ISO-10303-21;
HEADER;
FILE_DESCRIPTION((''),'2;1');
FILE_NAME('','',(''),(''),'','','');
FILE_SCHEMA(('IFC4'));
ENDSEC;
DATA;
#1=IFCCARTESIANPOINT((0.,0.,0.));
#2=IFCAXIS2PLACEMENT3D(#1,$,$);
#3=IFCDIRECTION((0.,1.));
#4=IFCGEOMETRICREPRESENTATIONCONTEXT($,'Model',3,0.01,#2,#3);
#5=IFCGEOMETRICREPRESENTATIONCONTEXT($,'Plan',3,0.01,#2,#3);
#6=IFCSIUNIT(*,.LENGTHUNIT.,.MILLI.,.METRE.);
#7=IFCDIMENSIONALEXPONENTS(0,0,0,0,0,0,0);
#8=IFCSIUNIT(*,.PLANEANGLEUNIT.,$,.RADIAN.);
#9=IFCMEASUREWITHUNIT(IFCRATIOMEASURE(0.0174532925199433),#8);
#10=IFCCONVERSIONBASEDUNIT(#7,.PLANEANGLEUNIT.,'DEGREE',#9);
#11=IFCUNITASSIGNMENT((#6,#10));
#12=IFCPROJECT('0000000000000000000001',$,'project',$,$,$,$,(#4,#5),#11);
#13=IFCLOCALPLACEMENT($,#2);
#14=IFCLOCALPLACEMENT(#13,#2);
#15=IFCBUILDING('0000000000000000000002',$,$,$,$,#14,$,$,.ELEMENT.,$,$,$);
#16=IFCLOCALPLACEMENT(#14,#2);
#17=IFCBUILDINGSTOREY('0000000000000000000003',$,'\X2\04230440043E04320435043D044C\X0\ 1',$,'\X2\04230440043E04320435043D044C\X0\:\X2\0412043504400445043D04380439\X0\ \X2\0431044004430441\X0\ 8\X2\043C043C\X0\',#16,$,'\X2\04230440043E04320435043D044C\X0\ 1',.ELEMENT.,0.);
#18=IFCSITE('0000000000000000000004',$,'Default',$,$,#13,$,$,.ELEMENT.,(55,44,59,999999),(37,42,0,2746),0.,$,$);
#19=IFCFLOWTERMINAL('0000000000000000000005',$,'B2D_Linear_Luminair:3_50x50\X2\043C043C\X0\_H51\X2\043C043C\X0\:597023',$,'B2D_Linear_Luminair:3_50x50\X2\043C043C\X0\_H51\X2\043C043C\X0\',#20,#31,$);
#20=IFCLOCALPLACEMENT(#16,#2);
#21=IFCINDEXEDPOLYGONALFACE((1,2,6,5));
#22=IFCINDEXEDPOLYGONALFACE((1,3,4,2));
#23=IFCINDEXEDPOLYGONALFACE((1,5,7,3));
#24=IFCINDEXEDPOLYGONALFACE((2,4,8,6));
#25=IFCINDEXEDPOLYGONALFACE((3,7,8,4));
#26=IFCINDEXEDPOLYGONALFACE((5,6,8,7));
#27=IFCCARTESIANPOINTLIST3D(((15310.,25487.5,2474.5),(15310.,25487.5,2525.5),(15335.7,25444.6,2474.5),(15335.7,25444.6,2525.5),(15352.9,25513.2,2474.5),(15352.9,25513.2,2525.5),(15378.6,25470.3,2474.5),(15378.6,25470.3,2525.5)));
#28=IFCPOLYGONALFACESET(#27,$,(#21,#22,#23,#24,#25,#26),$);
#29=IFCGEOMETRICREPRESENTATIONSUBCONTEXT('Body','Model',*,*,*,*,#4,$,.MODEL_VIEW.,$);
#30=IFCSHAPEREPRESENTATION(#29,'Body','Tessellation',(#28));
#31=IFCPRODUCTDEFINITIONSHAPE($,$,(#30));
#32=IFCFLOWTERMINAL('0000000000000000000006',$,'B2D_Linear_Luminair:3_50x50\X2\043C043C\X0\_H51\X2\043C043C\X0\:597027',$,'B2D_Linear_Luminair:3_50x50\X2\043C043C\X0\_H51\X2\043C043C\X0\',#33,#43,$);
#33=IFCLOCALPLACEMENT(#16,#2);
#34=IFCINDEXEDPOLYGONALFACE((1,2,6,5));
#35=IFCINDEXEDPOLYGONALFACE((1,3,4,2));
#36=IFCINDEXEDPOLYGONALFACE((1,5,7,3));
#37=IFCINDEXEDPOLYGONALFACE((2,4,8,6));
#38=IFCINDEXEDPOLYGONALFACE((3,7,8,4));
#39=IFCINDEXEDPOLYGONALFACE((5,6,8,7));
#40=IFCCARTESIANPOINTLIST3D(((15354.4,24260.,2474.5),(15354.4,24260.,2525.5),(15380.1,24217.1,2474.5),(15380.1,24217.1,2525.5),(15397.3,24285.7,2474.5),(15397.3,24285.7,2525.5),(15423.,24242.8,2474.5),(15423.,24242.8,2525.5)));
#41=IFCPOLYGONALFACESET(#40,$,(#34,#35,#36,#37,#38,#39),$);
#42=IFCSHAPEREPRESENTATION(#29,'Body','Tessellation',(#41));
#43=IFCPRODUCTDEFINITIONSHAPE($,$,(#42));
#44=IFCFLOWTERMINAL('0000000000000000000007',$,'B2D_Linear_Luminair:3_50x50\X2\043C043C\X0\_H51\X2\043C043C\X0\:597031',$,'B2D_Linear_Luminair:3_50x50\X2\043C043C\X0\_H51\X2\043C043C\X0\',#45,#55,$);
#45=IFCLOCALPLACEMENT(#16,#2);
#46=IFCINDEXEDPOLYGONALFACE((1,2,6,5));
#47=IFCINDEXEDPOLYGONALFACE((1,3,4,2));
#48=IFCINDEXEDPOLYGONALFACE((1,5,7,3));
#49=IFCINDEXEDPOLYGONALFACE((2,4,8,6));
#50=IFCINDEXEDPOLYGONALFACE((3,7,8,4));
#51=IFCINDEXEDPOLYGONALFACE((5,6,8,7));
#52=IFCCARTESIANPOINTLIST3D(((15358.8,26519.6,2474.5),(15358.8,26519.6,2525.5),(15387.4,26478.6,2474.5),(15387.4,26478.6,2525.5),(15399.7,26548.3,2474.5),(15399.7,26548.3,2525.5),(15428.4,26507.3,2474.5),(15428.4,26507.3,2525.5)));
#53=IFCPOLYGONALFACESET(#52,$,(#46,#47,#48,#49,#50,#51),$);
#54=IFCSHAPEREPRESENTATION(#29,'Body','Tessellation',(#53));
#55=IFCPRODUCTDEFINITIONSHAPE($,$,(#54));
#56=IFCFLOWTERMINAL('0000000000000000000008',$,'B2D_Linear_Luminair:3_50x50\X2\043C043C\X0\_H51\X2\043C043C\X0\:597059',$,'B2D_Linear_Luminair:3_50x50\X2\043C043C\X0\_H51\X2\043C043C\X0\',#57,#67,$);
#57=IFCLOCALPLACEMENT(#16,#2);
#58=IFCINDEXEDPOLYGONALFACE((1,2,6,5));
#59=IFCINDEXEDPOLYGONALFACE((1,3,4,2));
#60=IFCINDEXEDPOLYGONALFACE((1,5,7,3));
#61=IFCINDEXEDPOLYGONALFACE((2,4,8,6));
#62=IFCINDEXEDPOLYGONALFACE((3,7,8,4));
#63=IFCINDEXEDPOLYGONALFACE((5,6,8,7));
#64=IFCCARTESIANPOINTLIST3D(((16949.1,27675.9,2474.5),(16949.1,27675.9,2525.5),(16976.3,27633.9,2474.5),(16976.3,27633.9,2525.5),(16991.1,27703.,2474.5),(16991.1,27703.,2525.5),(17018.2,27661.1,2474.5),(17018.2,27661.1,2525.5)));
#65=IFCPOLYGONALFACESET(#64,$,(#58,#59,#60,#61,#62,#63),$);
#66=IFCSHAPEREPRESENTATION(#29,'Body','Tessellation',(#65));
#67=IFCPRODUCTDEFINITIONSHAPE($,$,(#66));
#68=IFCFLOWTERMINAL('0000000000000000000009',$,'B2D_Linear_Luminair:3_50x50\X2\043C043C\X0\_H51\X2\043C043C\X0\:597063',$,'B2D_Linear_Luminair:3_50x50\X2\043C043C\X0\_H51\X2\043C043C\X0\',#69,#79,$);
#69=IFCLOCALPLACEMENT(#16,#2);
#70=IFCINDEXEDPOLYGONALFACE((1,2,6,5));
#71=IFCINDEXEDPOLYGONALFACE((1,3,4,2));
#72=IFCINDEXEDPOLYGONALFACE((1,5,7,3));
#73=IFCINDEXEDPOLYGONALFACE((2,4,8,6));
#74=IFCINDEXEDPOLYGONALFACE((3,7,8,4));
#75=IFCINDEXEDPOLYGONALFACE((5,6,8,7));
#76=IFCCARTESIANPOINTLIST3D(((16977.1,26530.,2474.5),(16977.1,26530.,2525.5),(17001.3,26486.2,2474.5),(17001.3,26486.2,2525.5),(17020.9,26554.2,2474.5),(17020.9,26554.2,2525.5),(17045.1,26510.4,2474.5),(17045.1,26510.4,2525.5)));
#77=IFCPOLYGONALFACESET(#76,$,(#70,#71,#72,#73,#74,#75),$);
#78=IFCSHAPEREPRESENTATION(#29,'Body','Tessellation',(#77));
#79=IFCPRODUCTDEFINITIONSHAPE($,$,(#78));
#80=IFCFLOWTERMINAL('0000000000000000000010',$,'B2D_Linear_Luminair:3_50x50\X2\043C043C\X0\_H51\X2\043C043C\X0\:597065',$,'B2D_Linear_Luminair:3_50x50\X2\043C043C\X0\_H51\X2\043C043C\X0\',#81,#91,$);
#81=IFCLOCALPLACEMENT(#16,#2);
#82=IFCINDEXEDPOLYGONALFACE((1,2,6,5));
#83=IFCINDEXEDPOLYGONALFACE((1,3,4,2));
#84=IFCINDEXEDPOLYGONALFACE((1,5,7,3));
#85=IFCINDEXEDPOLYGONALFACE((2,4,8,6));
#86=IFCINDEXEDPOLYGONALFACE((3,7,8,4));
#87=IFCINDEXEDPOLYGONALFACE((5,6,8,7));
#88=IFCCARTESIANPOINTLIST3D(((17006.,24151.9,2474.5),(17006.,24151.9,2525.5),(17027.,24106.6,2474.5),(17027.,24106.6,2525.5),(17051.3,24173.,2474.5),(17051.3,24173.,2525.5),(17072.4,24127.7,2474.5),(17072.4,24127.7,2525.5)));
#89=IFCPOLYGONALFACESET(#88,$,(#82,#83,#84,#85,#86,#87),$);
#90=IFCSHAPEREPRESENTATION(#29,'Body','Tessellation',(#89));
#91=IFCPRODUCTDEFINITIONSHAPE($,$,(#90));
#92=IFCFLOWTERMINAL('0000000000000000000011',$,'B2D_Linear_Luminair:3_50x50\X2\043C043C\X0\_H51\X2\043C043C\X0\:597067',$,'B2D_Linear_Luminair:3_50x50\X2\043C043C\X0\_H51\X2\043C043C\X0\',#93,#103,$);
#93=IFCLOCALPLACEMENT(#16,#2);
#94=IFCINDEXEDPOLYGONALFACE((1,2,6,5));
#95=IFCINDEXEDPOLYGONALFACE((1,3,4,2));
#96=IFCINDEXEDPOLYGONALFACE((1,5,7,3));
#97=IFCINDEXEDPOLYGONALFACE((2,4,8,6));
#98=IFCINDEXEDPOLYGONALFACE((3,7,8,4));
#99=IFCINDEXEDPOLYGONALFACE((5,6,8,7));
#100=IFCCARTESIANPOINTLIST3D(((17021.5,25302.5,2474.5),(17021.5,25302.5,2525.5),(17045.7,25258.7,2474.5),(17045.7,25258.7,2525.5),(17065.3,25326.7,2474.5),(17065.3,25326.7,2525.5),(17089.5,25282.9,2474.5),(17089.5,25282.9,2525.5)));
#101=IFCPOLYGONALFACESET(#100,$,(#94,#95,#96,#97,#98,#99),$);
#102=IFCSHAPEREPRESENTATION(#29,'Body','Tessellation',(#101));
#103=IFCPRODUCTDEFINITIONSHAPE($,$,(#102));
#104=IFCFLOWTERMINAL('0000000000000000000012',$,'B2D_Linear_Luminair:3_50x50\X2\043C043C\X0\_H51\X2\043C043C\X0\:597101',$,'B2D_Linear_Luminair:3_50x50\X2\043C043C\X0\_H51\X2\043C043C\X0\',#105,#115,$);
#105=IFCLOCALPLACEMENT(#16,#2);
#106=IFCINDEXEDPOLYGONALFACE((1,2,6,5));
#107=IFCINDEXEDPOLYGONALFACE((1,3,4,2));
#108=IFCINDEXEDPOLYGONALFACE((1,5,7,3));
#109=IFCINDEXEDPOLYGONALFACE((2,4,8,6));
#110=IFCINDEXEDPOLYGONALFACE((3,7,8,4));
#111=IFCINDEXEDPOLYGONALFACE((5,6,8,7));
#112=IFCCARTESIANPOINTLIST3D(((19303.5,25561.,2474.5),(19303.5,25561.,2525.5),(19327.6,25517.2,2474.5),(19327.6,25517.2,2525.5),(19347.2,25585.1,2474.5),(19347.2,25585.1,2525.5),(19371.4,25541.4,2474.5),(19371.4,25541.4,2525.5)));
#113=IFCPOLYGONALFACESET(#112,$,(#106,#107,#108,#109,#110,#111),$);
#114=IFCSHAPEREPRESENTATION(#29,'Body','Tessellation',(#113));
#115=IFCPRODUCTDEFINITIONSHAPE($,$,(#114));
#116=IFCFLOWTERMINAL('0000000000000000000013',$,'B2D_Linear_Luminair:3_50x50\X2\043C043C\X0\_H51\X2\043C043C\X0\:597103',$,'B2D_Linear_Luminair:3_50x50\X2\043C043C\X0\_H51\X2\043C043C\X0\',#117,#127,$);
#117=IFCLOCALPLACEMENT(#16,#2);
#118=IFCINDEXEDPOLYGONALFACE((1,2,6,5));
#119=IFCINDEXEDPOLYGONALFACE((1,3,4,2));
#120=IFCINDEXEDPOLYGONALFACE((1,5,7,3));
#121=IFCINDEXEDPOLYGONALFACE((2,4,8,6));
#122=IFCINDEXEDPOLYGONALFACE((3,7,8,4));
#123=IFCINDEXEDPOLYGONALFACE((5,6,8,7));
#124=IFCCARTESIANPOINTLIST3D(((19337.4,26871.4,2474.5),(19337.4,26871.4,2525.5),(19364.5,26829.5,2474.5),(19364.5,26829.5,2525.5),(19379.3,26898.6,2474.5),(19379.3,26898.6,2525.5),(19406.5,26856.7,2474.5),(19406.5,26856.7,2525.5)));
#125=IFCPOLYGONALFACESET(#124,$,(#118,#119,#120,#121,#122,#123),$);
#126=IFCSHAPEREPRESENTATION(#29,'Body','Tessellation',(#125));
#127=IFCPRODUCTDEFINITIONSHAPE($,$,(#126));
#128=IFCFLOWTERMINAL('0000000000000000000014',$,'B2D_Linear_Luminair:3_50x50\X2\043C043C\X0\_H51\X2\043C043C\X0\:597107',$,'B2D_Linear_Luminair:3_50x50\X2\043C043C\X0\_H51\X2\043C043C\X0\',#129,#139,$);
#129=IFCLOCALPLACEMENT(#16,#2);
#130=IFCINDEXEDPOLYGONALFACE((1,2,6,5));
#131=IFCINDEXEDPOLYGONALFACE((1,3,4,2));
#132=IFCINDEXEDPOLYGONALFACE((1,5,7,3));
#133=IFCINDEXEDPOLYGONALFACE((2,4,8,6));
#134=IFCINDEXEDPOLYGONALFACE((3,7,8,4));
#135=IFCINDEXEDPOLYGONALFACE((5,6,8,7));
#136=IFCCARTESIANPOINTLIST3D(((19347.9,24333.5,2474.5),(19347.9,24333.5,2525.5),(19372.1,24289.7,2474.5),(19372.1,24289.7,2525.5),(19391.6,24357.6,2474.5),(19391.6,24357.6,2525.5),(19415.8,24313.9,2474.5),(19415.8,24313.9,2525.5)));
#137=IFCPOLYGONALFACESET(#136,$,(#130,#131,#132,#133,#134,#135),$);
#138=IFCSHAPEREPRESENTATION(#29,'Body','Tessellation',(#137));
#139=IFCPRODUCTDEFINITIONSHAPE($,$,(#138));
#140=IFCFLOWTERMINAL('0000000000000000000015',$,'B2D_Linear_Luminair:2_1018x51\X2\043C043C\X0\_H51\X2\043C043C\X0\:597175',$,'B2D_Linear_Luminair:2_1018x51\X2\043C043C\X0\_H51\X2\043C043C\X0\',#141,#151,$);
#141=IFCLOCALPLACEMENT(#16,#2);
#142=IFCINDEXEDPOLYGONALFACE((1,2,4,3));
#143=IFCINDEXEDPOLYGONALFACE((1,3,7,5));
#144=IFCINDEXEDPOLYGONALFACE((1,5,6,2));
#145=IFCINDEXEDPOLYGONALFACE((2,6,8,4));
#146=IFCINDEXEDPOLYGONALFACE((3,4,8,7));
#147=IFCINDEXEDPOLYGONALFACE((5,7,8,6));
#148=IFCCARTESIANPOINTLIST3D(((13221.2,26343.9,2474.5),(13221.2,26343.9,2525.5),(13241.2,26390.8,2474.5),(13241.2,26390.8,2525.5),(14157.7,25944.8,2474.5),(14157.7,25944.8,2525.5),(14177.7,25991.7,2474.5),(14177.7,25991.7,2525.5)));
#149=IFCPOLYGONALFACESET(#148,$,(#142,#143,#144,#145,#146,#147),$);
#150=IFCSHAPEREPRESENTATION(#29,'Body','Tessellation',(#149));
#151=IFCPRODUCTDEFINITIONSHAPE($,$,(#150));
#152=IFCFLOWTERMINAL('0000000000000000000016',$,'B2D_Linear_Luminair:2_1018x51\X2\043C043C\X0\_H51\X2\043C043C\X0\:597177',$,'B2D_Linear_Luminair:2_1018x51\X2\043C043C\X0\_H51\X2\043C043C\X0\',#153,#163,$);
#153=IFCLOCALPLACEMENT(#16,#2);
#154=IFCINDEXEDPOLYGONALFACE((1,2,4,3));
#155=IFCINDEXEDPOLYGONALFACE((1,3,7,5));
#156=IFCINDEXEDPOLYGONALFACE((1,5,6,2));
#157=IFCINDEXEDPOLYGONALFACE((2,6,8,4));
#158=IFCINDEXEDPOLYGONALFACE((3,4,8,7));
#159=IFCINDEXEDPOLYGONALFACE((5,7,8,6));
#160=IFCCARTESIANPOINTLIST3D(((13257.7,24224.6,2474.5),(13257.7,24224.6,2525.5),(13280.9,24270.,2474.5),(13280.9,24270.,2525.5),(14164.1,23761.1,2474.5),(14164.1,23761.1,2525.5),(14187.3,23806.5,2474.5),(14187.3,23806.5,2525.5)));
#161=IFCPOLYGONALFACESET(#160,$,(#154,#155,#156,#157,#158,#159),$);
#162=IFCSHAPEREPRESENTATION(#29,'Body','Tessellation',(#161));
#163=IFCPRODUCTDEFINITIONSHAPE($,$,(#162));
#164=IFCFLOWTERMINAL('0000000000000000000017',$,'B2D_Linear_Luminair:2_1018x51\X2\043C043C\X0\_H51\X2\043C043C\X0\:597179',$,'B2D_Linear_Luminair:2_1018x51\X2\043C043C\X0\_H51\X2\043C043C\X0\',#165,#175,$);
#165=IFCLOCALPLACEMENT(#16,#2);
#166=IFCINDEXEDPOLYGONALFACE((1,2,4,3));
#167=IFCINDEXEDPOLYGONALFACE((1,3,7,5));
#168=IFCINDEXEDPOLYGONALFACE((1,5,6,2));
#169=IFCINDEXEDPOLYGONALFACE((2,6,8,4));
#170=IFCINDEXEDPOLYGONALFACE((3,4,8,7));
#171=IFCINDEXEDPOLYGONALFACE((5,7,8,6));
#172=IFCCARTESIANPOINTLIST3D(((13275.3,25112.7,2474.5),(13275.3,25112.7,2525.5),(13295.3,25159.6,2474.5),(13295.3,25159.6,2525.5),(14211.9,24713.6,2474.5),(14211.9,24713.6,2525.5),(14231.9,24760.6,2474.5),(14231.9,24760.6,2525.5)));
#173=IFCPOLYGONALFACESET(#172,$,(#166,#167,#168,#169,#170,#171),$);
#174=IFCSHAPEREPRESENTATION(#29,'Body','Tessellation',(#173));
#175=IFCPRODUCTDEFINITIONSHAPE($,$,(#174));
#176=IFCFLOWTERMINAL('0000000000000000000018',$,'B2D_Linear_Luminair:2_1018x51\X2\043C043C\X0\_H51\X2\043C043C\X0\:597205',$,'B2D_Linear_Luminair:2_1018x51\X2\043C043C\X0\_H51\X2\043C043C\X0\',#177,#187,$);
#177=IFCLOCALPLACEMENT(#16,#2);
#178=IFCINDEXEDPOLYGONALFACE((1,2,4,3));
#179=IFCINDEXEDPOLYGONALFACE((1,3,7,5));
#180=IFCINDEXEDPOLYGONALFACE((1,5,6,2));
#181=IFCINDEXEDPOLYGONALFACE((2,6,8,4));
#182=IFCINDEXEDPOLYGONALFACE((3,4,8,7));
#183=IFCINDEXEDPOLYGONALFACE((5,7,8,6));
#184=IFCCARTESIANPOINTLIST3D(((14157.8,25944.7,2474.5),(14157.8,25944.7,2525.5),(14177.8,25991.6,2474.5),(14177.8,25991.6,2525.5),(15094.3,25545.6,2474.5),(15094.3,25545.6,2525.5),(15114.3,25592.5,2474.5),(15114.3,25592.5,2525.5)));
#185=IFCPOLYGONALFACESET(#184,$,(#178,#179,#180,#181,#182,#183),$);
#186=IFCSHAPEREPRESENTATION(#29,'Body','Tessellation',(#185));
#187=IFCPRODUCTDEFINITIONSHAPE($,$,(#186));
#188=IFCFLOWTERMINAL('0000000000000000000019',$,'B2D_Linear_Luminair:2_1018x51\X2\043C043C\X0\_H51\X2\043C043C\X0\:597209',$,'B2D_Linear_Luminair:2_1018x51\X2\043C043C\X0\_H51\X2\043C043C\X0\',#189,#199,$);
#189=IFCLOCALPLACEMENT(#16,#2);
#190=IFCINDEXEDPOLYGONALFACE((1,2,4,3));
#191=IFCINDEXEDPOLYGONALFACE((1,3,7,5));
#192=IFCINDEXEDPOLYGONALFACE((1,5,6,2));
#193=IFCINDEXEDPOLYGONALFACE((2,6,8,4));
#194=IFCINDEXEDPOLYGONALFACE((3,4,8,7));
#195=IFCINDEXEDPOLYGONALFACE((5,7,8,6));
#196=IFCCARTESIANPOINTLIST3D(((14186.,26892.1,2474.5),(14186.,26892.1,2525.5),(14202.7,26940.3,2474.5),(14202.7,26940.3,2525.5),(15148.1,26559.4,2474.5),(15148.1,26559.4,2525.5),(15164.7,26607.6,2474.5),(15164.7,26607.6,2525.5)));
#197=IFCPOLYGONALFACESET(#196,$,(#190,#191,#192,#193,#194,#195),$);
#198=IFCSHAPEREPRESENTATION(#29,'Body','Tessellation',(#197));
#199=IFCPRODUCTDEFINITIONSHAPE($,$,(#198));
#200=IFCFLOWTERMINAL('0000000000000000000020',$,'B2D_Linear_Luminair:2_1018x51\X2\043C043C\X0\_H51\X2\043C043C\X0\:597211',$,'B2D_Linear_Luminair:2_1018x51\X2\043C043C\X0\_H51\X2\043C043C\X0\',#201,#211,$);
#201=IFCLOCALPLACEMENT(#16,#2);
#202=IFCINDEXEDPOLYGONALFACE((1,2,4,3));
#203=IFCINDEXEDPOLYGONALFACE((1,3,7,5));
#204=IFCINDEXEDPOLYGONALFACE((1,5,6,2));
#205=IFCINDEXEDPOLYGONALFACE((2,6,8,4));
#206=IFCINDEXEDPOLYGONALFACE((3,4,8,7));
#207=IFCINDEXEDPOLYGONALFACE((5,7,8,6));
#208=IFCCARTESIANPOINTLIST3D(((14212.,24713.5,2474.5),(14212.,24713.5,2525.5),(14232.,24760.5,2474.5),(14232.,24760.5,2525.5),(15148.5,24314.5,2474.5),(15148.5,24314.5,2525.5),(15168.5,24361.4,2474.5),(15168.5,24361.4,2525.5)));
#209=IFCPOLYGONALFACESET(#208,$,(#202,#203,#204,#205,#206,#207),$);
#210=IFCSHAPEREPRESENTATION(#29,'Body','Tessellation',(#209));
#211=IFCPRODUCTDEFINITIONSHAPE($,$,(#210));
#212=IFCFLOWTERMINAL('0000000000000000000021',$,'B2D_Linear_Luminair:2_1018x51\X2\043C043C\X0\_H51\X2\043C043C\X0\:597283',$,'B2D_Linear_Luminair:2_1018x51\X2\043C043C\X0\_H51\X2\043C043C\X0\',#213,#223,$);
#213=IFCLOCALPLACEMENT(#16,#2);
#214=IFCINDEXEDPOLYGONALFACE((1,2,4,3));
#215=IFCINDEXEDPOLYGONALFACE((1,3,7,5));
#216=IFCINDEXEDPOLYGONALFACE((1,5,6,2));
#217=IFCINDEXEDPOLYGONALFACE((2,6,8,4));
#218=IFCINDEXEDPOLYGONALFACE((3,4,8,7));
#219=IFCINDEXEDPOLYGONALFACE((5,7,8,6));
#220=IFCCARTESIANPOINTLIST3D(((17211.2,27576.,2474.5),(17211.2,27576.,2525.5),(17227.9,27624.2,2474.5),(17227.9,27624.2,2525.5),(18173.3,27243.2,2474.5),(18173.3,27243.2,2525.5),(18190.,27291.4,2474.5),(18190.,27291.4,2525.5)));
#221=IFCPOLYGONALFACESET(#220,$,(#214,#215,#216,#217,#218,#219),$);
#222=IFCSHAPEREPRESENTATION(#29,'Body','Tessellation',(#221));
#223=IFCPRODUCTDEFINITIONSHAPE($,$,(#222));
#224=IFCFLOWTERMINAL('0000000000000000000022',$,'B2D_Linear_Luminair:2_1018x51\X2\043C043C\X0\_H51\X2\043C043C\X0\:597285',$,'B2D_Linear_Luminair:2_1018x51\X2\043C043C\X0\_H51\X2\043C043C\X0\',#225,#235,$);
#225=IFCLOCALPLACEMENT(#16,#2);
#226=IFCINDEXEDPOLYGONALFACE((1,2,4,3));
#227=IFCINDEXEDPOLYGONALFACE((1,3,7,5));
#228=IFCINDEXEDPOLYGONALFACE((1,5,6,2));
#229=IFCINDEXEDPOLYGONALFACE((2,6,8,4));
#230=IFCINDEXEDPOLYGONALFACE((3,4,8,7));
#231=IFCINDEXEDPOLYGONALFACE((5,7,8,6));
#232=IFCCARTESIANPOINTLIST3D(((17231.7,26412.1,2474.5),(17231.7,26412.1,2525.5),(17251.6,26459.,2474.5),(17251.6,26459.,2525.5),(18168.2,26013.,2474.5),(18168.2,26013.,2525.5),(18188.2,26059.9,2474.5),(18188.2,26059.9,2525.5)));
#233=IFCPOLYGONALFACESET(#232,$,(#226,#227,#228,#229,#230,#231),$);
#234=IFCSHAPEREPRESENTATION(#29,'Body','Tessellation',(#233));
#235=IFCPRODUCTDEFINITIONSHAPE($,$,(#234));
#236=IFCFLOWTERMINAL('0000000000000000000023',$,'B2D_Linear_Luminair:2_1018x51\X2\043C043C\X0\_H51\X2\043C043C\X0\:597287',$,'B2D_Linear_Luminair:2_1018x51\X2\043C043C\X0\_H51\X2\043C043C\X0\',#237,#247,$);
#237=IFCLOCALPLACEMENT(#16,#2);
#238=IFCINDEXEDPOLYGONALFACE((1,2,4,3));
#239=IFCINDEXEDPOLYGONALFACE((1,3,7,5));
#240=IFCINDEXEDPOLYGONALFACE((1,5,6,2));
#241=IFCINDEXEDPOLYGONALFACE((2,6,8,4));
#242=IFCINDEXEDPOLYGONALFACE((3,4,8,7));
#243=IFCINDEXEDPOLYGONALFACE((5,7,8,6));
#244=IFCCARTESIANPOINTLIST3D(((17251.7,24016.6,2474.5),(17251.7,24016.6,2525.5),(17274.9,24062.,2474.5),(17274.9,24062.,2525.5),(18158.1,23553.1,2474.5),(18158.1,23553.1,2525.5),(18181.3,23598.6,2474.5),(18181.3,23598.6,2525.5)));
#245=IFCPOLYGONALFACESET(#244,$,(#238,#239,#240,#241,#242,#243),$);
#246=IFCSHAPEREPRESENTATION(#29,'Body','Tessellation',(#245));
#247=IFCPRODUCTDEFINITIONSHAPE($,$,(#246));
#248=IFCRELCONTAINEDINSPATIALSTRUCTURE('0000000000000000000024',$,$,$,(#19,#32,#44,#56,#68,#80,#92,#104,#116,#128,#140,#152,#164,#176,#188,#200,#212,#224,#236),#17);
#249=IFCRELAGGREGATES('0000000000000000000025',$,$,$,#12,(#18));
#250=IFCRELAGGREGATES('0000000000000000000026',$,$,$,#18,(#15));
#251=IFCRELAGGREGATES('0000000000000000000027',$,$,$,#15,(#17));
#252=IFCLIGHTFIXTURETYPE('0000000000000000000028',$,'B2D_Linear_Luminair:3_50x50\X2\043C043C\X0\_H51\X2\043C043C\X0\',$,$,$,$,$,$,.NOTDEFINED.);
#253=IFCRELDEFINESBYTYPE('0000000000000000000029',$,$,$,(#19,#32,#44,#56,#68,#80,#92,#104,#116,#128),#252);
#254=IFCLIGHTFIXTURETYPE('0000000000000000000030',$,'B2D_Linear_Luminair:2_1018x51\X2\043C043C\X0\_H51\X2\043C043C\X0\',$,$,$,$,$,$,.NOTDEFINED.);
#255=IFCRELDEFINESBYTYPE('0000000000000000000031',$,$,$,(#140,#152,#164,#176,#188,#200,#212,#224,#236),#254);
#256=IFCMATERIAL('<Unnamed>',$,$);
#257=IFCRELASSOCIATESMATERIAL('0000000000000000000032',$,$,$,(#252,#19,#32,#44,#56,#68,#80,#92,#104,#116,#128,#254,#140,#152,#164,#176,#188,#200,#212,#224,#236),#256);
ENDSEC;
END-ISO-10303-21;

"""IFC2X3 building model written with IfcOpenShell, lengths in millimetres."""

from ifc_helpers import new_model, entity, si_unit, converted_unit, direction, frame, origin, origin_2d_with_axis, place, context, subcontext, project, spatial, rectangle, extrude, source, transform, mapped, material, type_object, type_shapes, element, save


model = new_model("IFC2X3")

# Units and contexts
model_context = context("Model", 3, precision=0.01, world=origin(), true_north=direction((0.0, 1.0)))
plan_context = context("Plan", 3, precision=0.01, world=origin(), true_north=direction((0.0, 1.0)))
body_context = subcontext(model_context, "Body", "Model", "MODEL_VIEW")
ifc_project = project(units=[si_unit("LENGTHUNIT", "METRE", prefix="MILLI"), converted_unit("PLANEANGLEUNIT", "DEGREE", entity("IfcRatioMeasure", 0.0174532925199433), si_unit("PLANEANGLEUNIT", "RADIAN"), dimensions=[0, 0, 0, 0, 0, 0, 0])], contexts=[model_context, plan_context])

# Site, building, storey
site_placement = place(None, origin())
site = spatial("IfcSite", under=ifc_project, at=site_placement, Name="Default", CompositionType="ELEMENT", RefLatitude=(55, 44, 59, 999999), RefLongitude=(37, 42, 0, 2746), RefElevation=0.0)
building_placement = place(site_placement, origin())
building = spatial("IfcBuilding", under=site, at=building_placement, CompositionType="ELEMENT")
storey_placement = place(building_placement, origin())
storey = spatial("IfcBuildingStorey", under=building, at=storey_placement, Name="Уровень 1", ObjectType="Уровень:Верхний брус 8мм", LongName="Уровень 1", CompositionType="ELEMENT", Elevation=0.0)

# Flow terminals
ifc_material = material(Name="<Unnamed>")
light_fixture_type_1 = type_object("IfcLightFixtureType", Name="B2D_Linear_Luminair:3_50x50мм_H51мм", PredefinedType="NOTDEFINED", material=ifc_material)
shared_shape_1 = source(origin(), body_context, "Body", "SweptSolid", [
    extrude(rectangle(XDim=50.0, YDim=50.0, at=origin_2d_with_axis()), frame((0.0, 0.0, 0.0), z_axis=(0.0, 0.0, 1.0), x_axis=(-1.0, 0.0, 0.0)), (0.0, 0.0, 1.0), 51.0),
])
type_shapes(light_fixture_type_1, [shared_shape_1])
for number, where, z_axis, x_axis, name in (
    (1, (15344.3, 25478.9, 2525.5), (0.0, 0.0, -1.0), (0.857886, 0.513841, 0.0), "B2D_Linear_Luminair:3_50x50мм_H51мм:597023"),
    (2, (15388.7, 24251.4, 2525.5), (0.0, 0.0, -1.0), (0.857886, 0.513841, 0.0), "B2D_Linear_Luminair:3_50x50мм_H51мм:597027"),
    (3, (15393.6, 26513.5, 2525.5), (0.0, 0.0, -1.0), (0.819952, 0.572432, 0.0), "B2D_Linear_Luminair:3_50x50мм_H51мм:597031"),
    (4, (16983.7, 27668.5, 2525.5), (0.0, 0.0, -1.0), (0.83943, 0.543467, 0.0), "B2D_Linear_Luminair:3_50x50мм_H51мм:597059"),
    (5, (17011.1, 26520.2, 2525.5), (0.0, 0.0, -1.0), (0.875296, 0.483588, 0.0), "B2D_Linear_Luminair:3_50x50мм_H51мм:597063"),
    (6, (17039.2, 24139.8, 2525.5), (0.0, 0.0, -1.0), (0.906897, 0.421352, 0.0), "B2D_Linear_Luminair:3_50x50мм_H51мм:597065"),
    (7, (17055.5, 25292.7, 2525.5), (0.0, 0.0, -1.0), (0.875296, 0.483588, 0.0), "B2D_Linear_Luminair:3_50x50мм_H51мм:597067"),
    (8, (19337.4, 25551.2, 2525.5), (0.0, 0.0, -1.0), (0.875296, 0.483588, 0.0), "B2D_Linear_Luminair:3_50x50мм_H51мм:597101"),
    (9, (19371.9, 26864.0, 2525.5), (0.0, 0.0, -1.0), (0.83943, 0.543467, 0.0), "B2D_Linear_Luminair:3_50x50мм_H51мм:597103"),
    (10, (19381.8, 24323.7, 2525.5), (0.0, 0.0, -1.0), (0.875296, 0.483588, 0.0), "B2D_Linear_Luminair:3_50x50мм_H51мм:597107"),
):
    element("IfcFlowTerminal", number, at=place(storey_placement, frame(where, z_axis=z_axis, x_axis=x_axis)), inside=storey, type_object=light_fixture_type_1, material=ifc_material, Name=name, ObjectType="B2D_Linear_Luminair:3_50x50мм_H51мм", context=body_context, shape_type="MappedRepresentation", body=[
        mapped(shared_shape_1, transform((0.0, 0.0, 0.0), scale=1.0)),
    ])
light_fixture_type_2 = type_object("IfcLightFixtureType", Name="B2D_Linear_Luminair:2_1018x51мм_H51мм", PredefinedType="NOTDEFINED", material=ifc_material)
shared_shape_2 = source(origin(), body_context, "Body", "SweptSolid", [
    extrude(rectangle(XDim=1018.0, YDim=51.0, at=origin_2d_with_axis()), frame((0.0, 0.0, 0.0), z_axis=(0.0, 0.0, 1.0), x_axis=(-1.0, 0.0, 0.0)), (0.0, 0.0, 1.0), 51.0),
])
type_shapes(light_fixture_type_2, [shared_shape_2])
for number, where, z_axis, x_axis, name in (
    (11, (13699.4, 26167.8, 2525.5), (0.0, 0.0, -1.0), (0.919958, -0.392016, 0.0), "B2D_Linear_Luminair:2_1018x51мм_H51мм:597175"),
    (12, (13722.5, 24015.5, 2525.5), (0.0, 0.0, -1.0), (0.890372, -0.455234, 0.0), "B2D_Linear_Luminair:2_1018x51мм_H51мм:597177"),
    (13, (13753.6, 24936.6, 2525.5), (0.0, 0.0, -1.0), (0.919958, -0.392016, 0.0), "B2D_Linear_Luminair:2_1018x51мм_H51мм:597179"),
    (14, (14636.1, 25768.6, 2525.5), (0.0, 0.0, -1.0), (0.919958, -0.392016, 0.0), "B2D_Linear_Luminair:2_1018x51мм_H51мм:597205"),
    (15, (14675.4, 26749.8, 2525.5), (0.0, 0.0, -1.0), (0.945063, -0.326888, 0.0), "B2D_Linear_Luminair:2_1018x51мм_H51мм:597209"),
    (16, (14690.2, 24537.5, 2525.5), (0.0, 0.0, -1.0), (0.919958, -0.392016, 0.0), "B2D_Linear_Luminair:2_1018x51мм_H51мм:597211"),
    (17, (17700.6, 27433.7, 2525.5), (0.0, 0.0, -1.0), (0.945063, -0.326888, 0.0), "B2D_Linear_Luminair:2_1018x51мм_H51мм:597283"),
    (18, (17709.9, 26236.0, 2525.5), (0.0, 0.0, -1.0), (0.919958, -0.392016, 0.0), "B2D_Linear_Luminair:2_1018x51мм_H51мм:597285"),
    (19, (17716.5, 23807.6, 2525.5), (0.0, 0.0, -1.0), (0.890372, -0.455234, 0.0), "B2D_Linear_Luminair:2_1018x51мм_H51мм:597287"),
):
    element("IfcFlowTerminal", number, at=place(storey_placement, frame(where, z_axis=z_axis, x_axis=x_axis)), inside=storey, type_object=light_fixture_type_2, material=ifc_material, Name=name, ObjectType="B2D_Linear_Luminair:2_1018x51мм_H51мм", context=body_context, shape_type="MappedRepresentation", body=[
        mapped(shared_shape_2, transform((0.0, 0.0, 0.0), scale=1.0)),
    ])

save(model, "model.ifc")
